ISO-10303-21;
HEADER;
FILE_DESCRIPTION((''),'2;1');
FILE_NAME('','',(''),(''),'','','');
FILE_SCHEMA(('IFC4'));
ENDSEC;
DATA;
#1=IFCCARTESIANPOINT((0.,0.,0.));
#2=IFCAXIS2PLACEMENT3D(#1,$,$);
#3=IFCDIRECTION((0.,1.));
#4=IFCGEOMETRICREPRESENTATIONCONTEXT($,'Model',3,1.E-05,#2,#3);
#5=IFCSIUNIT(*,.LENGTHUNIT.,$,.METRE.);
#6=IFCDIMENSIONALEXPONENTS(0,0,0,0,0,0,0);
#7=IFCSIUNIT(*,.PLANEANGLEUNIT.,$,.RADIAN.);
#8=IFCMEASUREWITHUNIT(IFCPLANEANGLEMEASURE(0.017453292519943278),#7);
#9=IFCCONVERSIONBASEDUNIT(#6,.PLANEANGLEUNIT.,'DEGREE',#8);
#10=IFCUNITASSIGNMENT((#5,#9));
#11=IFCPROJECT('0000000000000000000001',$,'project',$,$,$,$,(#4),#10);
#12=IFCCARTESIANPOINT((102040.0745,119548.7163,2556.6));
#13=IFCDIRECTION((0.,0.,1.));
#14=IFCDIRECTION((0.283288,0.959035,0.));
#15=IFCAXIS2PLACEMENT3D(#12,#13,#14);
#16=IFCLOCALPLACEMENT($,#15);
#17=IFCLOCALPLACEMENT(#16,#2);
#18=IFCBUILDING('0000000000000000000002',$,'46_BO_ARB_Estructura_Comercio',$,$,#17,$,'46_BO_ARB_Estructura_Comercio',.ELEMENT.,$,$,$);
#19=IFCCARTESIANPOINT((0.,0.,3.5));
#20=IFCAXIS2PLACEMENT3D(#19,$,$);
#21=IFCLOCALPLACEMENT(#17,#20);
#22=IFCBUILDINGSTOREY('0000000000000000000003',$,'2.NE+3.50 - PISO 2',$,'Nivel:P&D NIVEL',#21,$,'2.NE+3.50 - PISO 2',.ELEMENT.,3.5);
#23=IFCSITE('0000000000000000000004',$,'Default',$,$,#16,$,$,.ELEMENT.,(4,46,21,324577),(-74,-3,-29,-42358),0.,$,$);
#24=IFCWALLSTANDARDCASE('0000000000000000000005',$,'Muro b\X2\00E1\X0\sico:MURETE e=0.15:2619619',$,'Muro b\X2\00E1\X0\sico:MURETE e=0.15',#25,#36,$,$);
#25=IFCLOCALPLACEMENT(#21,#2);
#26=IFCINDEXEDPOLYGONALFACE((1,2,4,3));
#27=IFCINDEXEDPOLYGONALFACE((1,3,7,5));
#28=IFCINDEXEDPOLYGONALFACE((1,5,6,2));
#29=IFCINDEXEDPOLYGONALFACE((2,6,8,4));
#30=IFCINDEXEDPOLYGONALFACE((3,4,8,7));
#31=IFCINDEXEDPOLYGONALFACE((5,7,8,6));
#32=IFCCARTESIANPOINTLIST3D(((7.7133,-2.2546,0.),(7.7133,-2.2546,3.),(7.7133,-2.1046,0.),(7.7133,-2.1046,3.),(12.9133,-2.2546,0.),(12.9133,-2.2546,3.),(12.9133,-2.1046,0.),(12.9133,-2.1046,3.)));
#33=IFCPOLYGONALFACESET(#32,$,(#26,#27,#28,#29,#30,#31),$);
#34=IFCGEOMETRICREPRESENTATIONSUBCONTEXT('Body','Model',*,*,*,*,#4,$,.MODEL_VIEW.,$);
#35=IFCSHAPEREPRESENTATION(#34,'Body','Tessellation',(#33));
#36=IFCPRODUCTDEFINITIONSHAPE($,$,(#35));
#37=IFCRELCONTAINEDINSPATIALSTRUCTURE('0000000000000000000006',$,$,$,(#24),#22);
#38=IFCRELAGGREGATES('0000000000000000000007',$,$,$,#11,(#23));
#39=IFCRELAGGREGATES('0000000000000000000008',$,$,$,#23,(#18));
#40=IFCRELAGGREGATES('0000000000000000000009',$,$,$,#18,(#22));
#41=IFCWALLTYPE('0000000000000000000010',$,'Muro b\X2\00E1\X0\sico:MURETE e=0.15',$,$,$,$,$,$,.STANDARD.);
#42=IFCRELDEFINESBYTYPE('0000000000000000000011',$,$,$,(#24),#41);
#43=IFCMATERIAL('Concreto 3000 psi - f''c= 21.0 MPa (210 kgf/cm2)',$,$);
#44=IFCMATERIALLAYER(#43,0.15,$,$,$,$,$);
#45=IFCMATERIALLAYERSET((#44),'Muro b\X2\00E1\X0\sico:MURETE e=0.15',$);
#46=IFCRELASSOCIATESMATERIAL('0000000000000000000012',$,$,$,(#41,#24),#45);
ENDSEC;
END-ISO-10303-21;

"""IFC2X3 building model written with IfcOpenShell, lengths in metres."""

from ifc_helpers import new_model, entity, si_unit, converted_unit, direction, frame, frame_2d, origin, place, context, subcontext, project, spatial, rectangle, extrude, material, layer, layer_set, layer_usage, type_object, element, save


model = new_model("IFC2X3")

# Units and contexts
model_context = context("Model", 3, precision=1e-05, world=origin(), true_north=direction((0.0, 1.0)))
body_context = subcontext(model_context, "Body", "Model", "MODEL_VIEW")
ifc_project = project(units=[si_unit("LENGTHUNIT", "METRE"), converted_unit("PLANEANGLEUNIT", "DEGREE", entity("IfcPlaneAngleMeasure", 0.017453292519943278), si_unit("PLANEANGLEUNIT", "RADIAN"), dimensions=[0, 0, 0, 0, 0, 0, 0])], contexts=[model_context])

# Site, building, storey
site_placement = place(None, frame((102040.0745, 119548.7163, 2556.6), z_axis=(0.0, 0.0, 1.0), x_axis=(0.283288, 0.959035, 0.0)))
site = spatial("IfcSite", under=ifc_project, at=site_placement, Name="Default", CompositionType="ELEMENT", RefLatitude=(4, 46, 21, 324577), RefLongitude=(-74, -3, -29, -42358), RefElevation=0.0)
building_placement = place(site_placement, origin())
building = spatial("IfcBuilding", under=site, at=building_placement, Name="46_BO_ARB_Estructura_Comercio", LongName="46_BO_ARB_Estructura_Comercio", CompositionType="ELEMENT")
storey_placement = place(building_placement, frame((0.0, 0.0, 3.5)))
storey = spatial("IfcBuildingStorey", under=building, at=storey_placement, Name="2.NE+3.50 - PISO 2", ObjectType="Nivel:P&D NIVEL", LongName="2.NE+3.50 - PISO 2", CompositionType="ELEMENT", Elevation=3.5)

# Shared definitions
ifc_material = material(Name="Concreto 3000 psi - f'c= 21.0 MPa (210 kgf/cm2)")

# Wall
ifc_layer = layer(ifc_material, 0.15)
ifc_layer_set = layer_set([ifc_layer], Name="Muro básico:MURETE e=0.15")
ifc_layer_usage = layer_usage(ifc_layer_set, "AXIS2", "NEGATIVE", 0.075)
wall_type = type_object("IfcWallType", Name="Muro básico:MURETE e=0.15", PredefinedType="STANDARD", material=ifc_layer_set)
wall_placement = place(storey_placement, frame((7.7133, -2.1796, 0.0)))
element("IfcWallStandardCase", 1, at=wall_placement, inside=storey, type_object=wall_type, material=ifc_layer_usage, Name="Muro básico:MURETE e=0.15:2619619", ObjectType="Muro básico:MURETE e=0.15", context=body_context, shape_type="SweptSolid", body=[
    extrude(rectangle(XDim=5.2, YDim=0.15, at=frame_2d((2.6, 0.0), x_axis=(-1.0, 0.0))), origin(), (0.0, 0.0, 1.0), 3.0),
])

save(model, "model.ifc")
